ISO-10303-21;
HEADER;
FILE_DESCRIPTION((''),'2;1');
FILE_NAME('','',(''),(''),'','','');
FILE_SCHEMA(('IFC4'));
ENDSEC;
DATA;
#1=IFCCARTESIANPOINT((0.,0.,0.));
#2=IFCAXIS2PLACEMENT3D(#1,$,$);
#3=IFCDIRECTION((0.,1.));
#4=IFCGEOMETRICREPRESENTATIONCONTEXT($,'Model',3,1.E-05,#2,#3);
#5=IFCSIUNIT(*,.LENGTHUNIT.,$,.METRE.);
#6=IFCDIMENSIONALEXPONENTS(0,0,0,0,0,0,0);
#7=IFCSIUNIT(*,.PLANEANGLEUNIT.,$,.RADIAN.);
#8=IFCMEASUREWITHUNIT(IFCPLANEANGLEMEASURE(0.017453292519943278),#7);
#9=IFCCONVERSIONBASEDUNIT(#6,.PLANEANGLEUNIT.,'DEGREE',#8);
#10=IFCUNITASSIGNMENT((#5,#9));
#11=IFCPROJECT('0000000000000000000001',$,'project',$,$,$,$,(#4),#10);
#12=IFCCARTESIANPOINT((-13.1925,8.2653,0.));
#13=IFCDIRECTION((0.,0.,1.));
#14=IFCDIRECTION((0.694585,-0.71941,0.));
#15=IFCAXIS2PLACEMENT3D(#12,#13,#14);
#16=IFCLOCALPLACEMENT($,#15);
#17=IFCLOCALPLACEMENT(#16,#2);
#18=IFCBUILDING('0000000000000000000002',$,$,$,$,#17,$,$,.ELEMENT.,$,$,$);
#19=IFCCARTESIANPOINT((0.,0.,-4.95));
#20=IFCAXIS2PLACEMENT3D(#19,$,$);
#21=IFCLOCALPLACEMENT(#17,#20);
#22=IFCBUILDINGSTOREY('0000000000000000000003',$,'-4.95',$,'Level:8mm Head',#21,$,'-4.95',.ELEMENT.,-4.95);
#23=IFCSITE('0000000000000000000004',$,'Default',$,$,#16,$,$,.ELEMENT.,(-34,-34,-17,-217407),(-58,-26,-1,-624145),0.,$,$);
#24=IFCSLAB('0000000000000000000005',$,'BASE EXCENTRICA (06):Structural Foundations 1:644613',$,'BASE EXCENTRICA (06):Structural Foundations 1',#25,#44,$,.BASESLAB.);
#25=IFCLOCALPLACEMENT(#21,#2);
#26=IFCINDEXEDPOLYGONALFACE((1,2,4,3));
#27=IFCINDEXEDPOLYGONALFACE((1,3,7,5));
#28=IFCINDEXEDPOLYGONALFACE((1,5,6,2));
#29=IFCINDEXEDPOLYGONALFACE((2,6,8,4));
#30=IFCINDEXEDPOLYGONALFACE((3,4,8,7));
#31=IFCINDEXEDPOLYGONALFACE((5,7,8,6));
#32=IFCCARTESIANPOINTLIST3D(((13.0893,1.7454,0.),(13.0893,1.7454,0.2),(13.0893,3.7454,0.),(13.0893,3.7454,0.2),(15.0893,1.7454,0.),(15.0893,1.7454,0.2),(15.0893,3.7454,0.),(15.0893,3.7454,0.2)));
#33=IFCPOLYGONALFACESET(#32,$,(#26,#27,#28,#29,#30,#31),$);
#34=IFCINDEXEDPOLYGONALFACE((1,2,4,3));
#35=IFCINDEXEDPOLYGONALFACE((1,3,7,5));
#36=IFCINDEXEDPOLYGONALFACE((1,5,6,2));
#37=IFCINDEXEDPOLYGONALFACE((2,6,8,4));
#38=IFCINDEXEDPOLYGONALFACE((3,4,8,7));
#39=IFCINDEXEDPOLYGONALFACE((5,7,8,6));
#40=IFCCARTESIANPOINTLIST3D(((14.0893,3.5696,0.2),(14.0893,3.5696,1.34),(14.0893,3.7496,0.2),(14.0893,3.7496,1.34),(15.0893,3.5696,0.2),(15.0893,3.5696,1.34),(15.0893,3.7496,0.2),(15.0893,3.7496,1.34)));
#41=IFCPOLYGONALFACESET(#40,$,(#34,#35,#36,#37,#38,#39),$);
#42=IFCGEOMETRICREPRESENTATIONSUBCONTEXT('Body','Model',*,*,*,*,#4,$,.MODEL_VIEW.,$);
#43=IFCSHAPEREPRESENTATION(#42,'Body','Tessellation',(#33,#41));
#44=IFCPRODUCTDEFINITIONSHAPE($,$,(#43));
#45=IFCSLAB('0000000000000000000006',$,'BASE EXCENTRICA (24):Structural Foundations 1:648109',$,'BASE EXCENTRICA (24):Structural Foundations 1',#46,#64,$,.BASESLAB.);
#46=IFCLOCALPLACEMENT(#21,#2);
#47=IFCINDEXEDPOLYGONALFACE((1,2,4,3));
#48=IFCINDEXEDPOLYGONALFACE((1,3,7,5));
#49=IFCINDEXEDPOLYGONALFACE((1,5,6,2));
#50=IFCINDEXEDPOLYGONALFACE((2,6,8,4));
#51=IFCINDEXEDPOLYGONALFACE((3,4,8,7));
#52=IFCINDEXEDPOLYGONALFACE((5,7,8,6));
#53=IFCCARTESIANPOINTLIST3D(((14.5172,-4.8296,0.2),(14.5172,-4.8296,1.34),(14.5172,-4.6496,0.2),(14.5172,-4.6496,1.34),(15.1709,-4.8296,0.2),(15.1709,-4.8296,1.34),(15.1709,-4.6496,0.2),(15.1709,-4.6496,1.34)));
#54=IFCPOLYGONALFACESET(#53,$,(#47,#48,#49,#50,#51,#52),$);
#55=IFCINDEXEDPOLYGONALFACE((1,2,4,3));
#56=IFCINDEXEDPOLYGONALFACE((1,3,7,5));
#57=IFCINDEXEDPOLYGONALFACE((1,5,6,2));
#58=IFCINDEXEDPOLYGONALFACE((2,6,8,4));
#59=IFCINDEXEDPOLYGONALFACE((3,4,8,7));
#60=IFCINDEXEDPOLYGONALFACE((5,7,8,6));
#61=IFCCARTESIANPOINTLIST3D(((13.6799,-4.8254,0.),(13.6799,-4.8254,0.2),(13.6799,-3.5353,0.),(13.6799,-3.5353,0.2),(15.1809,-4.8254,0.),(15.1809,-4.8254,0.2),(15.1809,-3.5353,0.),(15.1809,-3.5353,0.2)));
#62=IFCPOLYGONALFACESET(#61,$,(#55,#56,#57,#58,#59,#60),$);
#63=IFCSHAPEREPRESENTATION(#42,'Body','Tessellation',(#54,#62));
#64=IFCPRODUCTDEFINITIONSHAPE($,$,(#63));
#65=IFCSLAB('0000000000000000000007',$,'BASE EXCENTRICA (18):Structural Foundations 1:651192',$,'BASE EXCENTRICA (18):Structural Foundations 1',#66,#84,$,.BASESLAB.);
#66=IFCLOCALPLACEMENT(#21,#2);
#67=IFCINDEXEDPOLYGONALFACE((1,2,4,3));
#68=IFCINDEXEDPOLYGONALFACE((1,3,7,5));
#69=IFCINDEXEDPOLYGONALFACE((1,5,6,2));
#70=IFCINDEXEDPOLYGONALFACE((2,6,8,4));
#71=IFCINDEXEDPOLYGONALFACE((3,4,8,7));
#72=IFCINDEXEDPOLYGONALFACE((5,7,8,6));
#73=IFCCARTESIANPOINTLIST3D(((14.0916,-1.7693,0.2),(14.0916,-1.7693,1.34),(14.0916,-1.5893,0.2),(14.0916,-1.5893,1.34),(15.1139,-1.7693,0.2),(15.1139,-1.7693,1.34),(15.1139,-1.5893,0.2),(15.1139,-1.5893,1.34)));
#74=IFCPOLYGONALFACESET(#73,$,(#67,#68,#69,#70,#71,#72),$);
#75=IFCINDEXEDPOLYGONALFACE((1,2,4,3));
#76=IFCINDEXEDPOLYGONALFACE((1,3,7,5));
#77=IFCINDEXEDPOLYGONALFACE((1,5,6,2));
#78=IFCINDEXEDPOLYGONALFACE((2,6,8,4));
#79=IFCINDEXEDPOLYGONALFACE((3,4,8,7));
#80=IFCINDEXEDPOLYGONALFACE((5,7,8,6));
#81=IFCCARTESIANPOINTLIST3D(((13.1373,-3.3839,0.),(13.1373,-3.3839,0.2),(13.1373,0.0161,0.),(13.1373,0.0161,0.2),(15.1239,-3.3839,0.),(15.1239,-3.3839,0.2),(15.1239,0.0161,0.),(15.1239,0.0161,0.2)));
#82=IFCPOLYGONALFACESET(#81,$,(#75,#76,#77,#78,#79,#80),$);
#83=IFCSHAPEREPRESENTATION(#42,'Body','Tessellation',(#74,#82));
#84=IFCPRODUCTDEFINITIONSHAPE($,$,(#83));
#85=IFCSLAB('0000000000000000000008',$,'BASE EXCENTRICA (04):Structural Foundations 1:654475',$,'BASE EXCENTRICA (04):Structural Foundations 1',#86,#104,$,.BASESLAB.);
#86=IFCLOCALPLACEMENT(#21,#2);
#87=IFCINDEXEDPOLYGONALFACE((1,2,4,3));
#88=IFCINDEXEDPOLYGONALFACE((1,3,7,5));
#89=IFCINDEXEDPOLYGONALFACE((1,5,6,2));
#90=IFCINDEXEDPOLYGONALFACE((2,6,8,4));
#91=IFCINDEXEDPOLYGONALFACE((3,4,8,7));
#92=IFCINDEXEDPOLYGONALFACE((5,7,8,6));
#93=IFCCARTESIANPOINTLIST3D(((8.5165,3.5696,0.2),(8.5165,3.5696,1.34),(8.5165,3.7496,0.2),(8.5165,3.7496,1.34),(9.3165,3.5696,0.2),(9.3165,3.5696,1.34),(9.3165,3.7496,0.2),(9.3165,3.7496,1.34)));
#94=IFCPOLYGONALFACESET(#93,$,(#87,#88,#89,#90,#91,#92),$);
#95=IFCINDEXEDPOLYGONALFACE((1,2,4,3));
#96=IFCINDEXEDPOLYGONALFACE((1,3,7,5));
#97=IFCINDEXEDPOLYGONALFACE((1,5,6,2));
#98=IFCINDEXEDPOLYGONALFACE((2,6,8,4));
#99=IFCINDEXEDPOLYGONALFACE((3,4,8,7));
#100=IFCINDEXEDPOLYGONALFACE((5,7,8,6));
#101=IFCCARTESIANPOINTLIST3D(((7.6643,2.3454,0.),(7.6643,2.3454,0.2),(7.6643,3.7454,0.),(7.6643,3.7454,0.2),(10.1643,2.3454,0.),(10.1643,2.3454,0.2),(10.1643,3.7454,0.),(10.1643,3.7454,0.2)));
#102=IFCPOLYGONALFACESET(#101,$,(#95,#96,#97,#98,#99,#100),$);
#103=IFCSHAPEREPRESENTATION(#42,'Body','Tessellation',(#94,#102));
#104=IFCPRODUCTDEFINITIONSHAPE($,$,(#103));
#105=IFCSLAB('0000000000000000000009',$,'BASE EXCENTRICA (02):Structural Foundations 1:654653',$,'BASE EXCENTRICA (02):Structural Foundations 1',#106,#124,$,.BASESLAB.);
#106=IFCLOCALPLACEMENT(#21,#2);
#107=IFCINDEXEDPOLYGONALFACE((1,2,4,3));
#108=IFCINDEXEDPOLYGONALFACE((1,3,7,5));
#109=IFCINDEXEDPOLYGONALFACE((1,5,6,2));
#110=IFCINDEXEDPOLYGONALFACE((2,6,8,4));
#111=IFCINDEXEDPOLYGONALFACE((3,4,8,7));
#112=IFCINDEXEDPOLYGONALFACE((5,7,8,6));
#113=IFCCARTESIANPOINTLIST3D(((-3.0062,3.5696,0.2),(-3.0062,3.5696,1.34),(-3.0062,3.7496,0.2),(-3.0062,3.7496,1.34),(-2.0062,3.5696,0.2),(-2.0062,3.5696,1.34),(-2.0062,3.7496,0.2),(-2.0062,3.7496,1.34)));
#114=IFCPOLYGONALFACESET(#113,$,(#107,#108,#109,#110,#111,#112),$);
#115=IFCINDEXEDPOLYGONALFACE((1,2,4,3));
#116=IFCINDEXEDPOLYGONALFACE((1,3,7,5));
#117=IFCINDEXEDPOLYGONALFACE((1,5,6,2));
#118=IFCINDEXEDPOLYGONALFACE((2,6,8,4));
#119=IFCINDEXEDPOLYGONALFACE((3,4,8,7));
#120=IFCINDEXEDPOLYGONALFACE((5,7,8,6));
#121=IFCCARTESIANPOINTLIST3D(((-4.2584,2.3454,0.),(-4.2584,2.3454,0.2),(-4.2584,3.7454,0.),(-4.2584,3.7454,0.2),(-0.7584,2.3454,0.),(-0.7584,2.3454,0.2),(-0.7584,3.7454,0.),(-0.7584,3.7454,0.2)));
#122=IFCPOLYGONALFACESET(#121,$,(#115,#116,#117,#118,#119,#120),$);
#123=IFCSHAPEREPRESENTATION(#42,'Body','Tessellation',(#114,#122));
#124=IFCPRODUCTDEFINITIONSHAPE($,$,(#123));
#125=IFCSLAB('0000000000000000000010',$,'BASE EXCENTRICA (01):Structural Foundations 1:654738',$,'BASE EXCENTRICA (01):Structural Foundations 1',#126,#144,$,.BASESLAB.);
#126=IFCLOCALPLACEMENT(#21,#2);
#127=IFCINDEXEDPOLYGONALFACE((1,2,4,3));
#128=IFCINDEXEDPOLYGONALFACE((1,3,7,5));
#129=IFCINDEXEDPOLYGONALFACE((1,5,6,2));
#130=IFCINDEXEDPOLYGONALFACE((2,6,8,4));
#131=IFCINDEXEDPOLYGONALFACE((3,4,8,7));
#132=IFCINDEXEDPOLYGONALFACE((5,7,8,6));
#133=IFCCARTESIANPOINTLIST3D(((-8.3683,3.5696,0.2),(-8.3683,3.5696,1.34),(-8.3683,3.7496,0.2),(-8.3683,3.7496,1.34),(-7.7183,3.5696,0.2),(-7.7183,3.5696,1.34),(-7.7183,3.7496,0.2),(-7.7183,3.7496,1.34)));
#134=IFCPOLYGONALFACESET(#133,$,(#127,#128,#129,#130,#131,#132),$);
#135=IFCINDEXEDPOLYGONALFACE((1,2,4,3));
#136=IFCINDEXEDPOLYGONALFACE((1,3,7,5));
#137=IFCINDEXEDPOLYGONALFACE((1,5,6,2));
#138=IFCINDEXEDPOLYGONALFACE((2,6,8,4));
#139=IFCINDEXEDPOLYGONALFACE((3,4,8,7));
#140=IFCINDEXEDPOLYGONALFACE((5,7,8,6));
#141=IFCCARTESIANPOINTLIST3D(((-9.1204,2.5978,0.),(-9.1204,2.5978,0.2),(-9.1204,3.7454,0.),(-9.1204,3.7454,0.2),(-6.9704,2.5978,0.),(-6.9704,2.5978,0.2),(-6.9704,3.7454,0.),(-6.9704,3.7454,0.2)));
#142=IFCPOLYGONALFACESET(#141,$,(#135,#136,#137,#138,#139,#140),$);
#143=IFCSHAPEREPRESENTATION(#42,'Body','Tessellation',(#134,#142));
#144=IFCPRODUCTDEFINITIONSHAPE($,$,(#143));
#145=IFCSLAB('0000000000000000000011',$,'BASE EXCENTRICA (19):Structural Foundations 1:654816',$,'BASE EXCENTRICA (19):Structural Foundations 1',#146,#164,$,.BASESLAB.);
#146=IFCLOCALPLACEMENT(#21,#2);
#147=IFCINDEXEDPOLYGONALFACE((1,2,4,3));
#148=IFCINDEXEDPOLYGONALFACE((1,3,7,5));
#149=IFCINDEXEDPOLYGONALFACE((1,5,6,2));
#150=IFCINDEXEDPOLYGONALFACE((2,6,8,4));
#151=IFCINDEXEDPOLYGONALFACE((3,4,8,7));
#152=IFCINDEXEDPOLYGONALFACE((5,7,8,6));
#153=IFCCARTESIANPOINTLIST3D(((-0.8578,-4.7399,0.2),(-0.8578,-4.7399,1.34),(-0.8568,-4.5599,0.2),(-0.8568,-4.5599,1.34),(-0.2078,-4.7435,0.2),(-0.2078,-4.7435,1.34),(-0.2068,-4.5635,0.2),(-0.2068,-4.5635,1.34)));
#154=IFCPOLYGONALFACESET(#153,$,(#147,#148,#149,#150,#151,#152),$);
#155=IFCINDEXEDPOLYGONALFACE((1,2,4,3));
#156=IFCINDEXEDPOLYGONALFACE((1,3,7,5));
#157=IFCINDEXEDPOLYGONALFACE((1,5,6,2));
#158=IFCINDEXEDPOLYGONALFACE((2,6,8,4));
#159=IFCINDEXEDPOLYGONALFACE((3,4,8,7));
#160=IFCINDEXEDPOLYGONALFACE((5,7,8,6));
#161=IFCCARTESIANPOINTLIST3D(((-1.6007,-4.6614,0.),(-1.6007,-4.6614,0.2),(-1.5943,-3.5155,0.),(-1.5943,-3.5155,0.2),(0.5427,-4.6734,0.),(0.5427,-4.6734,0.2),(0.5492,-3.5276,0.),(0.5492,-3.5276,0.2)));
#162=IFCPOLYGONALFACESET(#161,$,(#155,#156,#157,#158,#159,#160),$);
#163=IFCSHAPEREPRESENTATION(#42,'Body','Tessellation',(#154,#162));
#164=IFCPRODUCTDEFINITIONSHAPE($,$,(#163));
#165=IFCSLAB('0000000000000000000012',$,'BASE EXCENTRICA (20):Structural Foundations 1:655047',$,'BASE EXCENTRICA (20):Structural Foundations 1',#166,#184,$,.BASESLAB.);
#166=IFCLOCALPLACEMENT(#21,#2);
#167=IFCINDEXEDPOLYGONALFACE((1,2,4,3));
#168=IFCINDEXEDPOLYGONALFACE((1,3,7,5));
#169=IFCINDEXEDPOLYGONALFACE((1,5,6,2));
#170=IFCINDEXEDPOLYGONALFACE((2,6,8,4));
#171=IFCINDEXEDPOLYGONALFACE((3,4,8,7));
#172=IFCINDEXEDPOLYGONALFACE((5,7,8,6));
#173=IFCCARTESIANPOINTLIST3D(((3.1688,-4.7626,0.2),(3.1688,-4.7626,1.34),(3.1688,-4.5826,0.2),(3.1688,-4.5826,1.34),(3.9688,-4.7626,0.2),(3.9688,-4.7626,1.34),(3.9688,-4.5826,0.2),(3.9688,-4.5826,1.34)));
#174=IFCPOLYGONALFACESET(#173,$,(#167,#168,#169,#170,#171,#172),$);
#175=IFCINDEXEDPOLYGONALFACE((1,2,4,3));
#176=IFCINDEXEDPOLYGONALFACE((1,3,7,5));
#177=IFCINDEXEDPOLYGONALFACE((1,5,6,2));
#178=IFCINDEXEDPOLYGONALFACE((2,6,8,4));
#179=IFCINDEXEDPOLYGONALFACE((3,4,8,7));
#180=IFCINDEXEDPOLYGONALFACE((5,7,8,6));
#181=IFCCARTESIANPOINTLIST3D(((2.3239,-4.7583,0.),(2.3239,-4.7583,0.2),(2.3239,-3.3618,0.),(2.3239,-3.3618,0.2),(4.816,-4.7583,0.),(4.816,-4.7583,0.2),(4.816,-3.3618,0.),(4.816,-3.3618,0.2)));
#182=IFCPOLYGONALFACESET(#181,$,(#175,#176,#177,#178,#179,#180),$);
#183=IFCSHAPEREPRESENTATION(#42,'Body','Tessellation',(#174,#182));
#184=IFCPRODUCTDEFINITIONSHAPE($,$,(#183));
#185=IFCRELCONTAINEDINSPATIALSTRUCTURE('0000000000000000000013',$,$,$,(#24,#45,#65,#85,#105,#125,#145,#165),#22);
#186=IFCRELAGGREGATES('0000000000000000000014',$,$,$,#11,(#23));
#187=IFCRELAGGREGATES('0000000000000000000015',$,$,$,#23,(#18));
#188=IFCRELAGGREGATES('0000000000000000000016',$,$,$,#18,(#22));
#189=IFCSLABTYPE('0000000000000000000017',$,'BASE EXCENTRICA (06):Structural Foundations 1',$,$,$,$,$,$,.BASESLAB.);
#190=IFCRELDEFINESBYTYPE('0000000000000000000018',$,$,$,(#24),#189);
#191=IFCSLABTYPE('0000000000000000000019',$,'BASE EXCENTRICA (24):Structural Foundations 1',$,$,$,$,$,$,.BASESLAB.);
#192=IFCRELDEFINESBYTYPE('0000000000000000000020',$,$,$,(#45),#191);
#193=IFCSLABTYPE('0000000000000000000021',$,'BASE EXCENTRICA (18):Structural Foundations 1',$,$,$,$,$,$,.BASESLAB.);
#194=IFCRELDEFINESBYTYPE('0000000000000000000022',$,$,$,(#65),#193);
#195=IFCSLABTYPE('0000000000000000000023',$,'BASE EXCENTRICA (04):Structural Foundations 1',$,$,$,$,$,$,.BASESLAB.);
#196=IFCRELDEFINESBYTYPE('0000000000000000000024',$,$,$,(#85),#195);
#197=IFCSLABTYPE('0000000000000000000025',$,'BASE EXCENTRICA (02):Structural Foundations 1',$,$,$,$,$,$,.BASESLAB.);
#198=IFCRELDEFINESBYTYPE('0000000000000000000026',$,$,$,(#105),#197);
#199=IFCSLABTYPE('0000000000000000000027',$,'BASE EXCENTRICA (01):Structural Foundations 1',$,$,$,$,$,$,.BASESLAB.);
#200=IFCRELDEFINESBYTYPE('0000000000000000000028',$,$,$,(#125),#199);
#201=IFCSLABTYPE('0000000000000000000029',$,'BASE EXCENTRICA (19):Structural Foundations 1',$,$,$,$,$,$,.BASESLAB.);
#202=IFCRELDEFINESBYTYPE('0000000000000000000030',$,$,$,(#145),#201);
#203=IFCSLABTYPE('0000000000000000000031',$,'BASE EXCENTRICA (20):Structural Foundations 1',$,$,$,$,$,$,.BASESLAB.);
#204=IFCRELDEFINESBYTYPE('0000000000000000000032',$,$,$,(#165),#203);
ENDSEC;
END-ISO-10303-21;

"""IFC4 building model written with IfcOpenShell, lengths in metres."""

from ifc_helpers import new_model, entity, si_unit, converted_unit, direction, frame, origin, place, context, subcontext, project, spatial, indexed_curve, outline, extrude, type_object, element, save


model = new_model("IFC4")

# Units and contexts
model_context = context("Model", 3, precision=1e-05, world=origin(), true_north=direction((0.0, 1.0)))
body_context = subcontext(model_context, "Body", "Model", "MODEL_VIEW")
ifc_project = project(units=[si_unit("LENGTHUNIT", "METRE"), converted_unit("PLANEANGLEUNIT", "DEGREE", entity("IfcPlaneAngleMeasure", 0.017453292519943278), si_unit("PLANEANGLEUNIT", "RADIAN"), dimensions=[0, 0, 0, 0, 0, 0, 0])], contexts=[model_context])

# Site, building, storey
site_placement = place(None, frame((-13.1925, 8.2653, 0.0), z_axis=(0.0, 0.0, 1.0), x_axis=(0.694585, -0.71941, 0.0)))
site = spatial("IfcSite", under=ifc_project, at=site_placement, Name="Default", CompositionType="ELEMENT", RefLatitude=(-34, -34, -17, -217407), RefLongitude=(-58, -26, -1, -624145), RefElevation=0.0)
building_placement = place(site_placement, origin())
building = spatial("IfcBuilding", under=site, at=building_placement, CompositionType="ELEMENT")
storey_placement = place(building_placement, frame((0.0, 0.0, -4.95)))
storey = spatial("IfcBuildingStorey", under=building, at=storey_placement, Name="-4.95", ObjectType="Level:8mm Head", LongName="-4.95", CompositionType="ELEMENT", Elevation=-4.95)

# Slabs
slab_type_1 = type_object("IfcSlabType", Name="BASE EXCENTRICA (06):Structural Foundations 1", PredefinedType="BASESLAB")
slab_1_placement = place(storey_placement, origin())
element("IfcSlab", 1, at=slab_1_placement, inside=storey, type_object=slab_type_1, Name="BASE EXCENTRICA (06):Structural Foundations 1:644613", ObjectType="BASE EXCENTRICA (06):Structural Foundations 1", PredefinedType="BASESLAB", context=body_context, shape_type="SweptSolid", body=[
    extrude(outline(indexed_curve([(-1.0, -1.0), (1.0, -1.0), (1.0, 1.0), (-1.0, 1.0), (-1.0, -1.0)], self_intersect=False)), frame((14.0893, 2.7454, 0.0), z_axis=(0.0, 0.0, 1.0), x_axis=(0.0, -1.0, 0.0)), (0.0, 0.0, 1.0), 0.2),
    extrude(outline(indexed_curve([(-0.5, -0.09), (0.5, -0.09), (0.5, 0.09), (-0.5, 0.09), (-0.5, -0.09)], self_intersect=False)), frame((14.5893, 3.6596, 0.2), z_axis=(0.0, 0.0, 1.0), x_axis=(-1.0, 0.0, 0.0)), (0.0, 0.0, 1.0), 1.14),
])
slab_type_2 = type_object("IfcSlabType", Name="BASE EXCENTRICA (24):Structural Foundations 1", PredefinedType="BASESLAB")
slab_2_placement = place(storey_placement, origin())
element("IfcSlab", 2, at=slab_2_placement, inside=storey, type_object=slab_type_2, Name="BASE EXCENTRICA (24):Structural Foundations 1:648109", ObjectType="BASE EXCENTRICA (24):Structural Foundations 1", PredefinedType="BASESLAB", context=body_context, shape_type="SweptSolid", body=[
    extrude(outline(indexed_curve([(-0.09, -0.3268), (0.09, -0.3268), (0.09, 0.3268), (-0.09, 0.3268), (-0.09, -0.3268)], self_intersect=False)), frame((14.8441, -4.7396, 0.2), z_axis=(0.0, 0.0, 1.0), x_axis=(0.0, 1.0, 0.0)), (0.0, 0.0, 1.0), 1.14),
    extrude(outline(indexed_curve([(-0.7505, -0.645), (0.7505, -0.645), (0.7505, 0.645), (-0.7505, 0.645), (-0.7505, -0.645)], self_intersect=False)), frame((14.4304, -4.1803, 0.0)), (0.0, 0.0, 1.0), 0.2),
])
slab_type_3 = type_object("IfcSlabType", Name="BASE EXCENTRICA (18):Structural Foundations 1", PredefinedType="BASESLAB")
slab_3_placement = place(storey_placement, origin())
element("IfcSlab", 3, at=slab_3_placement, inside=storey, type_object=slab_type_3, Name="BASE EXCENTRICA (18):Structural Foundations 1:651192", ObjectType="BASE EXCENTRICA (18):Structural Foundations 1", PredefinedType="BASESLAB", context=body_context, shape_type="SweptSolid", body=[
    extrude(outline(indexed_curve([(-0.09, -0.5111), (0.09, -0.5111), (0.09, 0.5111), (-0.09, 0.5111), (-0.09, -0.5111)], self_intersect=False)), frame((14.6027, -1.6793, 0.2), z_axis=(0.0, 0.0, 1.0), x_axis=(0.0, 1.0, 0.0)), (0.0, 0.0, 1.0), 1.14),
    extrude(outline(indexed_curve([(-0.9933, -1.7), (0.9933, -1.7), (0.9933, 1.7), (-0.9933, 1.7), (-0.9933, -1.7)], self_intersect=False)), frame((14.1306, -1.6839, 0.0)), (0.0, 0.0, 1.0), 0.2),
])
slab_type_4 = type_object("IfcSlabType", Name="BASE EXCENTRICA (04):Structural Foundations 1", PredefinedType="BASESLAB")
slab_4_placement = place(storey_placement, origin())
element("IfcSlab", 4, at=slab_4_placement, inside=storey, type_object=slab_type_4, Name="BASE EXCENTRICA (04):Structural Foundations 1:654475", ObjectType="BASE EXCENTRICA (04):Structural Foundations 1", PredefinedType="BASESLAB", context=body_context, shape_type="SweptSolid", body=[
    extrude(outline(indexed_curve([(-0.4, -0.09), (0.4, -0.09), (0.4, 0.09), (-0.4, 0.09), (-0.4, -0.09)], self_intersect=False)), frame((8.9165, 3.6596, 0.2), z_axis=(0.0, 0.0, 1.0), x_axis=(-1.0, 0.0, 0.0)), (0.0, 0.0, 1.0), 1.14),
    extrude(outline(indexed_curve([(-0.7, -1.25), (0.7, -1.25), (0.7, 1.25), (-0.7, 1.25), (-0.7, -1.25)], self_intersect=False)), frame((8.9143, 3.0454, 0.0), z_axis=(0.0, 0.0, 1.0), x_axis=(0.0, -1.0, 0.0)), (0.0, 0.0, 1.0), 0.2),
])
slab_type_5 = type_object("IfcSlabType", Name="BASE EXCENTRICA (02):Structural Foundations 1", PredefinedType="BASESLAB")
slab_5_placement = place(storey_placement, origin())
element("IfcSlab", 5, at=slab_5_placement, inside=storey, type_object=slab_type_5, Name="BASE EXCENTRICA (02):Structural Foundations 1:654653", ObjectType="BASE EXCENTRICA (02):Structural Foundations 1", PredefinedType="BASESLAB", context=body_context, shape_type="SweptSolid", body=[
    extrude(outline(indexed_curve([(-0.5, -0.09), (0.5, -0.09), (0.5, 0.09), (-0.5, 0.09), (-0.5, -0.09)], self_intersect=False)), frame((-2.5062, 3.6596, 0.2), z_axis=(0.0, 0.0, 1.0), x_axis=(-1.0, 0.0, 0.0)), (0.0, 0.0, 1.0), 1.14),
    extrude(outline(indexed_curve([(-0.7, -1.75), (0.7, -1.75), (0.7, 1.75), (-0.7, 1.75), (-0.7, -1.75)], self_intersect=False)), frame((-2.5084, 3.0454, 0.0), z_axis=(0.0, 0.0, 1.0), x_axis=(0.0, -1.0, 0.0)), (0.0, 0.0, 1.0), 0.2),
])
slab_type_6 = type_object("IfcSlabType", Name="BASE EXCENTRICA (01):Structural Foundations 1", PredefinedType="BASESLAB")
slab_6_placement = place(storey_placement, origin())
element("IfcSlab", 6, at=slab_6_placement, inside=storey, type_object=slab_type_6, Name="BASE EXCENTRICA (01):Structural Foundations 1:654738", ObjectType="BASE EXCENTRICA (01):Structural Foundations 1", PredefinedType="BASESLAB", context=body_context, shape_type="SweptSolid", body=[
    extrude(outline(indexed_curve([(-0.325, -0.09), (0.325, -0.09), (0.325, 0.09), (-0.325, 0.09), (-0.325, -0.09)], self_intersect=False)), frame((-8.0433, 3.6596, 0.2), z_axis=(0.0, 0.0, 1.0), x_axis=(-1.0, 0.0, 0.0)), (0.0, 0.0, 1.0), 1.14),
    extrude(outline(indexed_curve([(-0.5738, -1.075), (0.5738, -1.075), (0.5738, 1.075), (-0.5738, 1.075), (-0.5738, -1.075)], self_intersect=False)), frame((-8.0454, 3.1716, 0.0), z_axis=(0.0, 0.0, 1.0), x_axis=(0.0, -1.0, 0.0)), (0.0, 0.0, 1.0), 0.2),
])
slab_type_7 = type_object("IfcSlabType", Name="BASE EXCENTRICA (19):Structural Foundations 1", PredefinedType="BASESLAB")
slab_7_placement = place(storey_placement, origin())
element("IfcSlab", 7, at=slab_7_placement, inside=storey, type_object=slab_type_7, Name="BASE EXCENTRICA (19):Structural Foundations 1:654816", ObjectType="BASE EXCENTRICA (19):Structural Foundations 1", PredefinedType="BASESLAB", context=body_context, shape_type="SweptSolid", body=[
    extrude(outline(indexed_curve([(-0.09, -0.325), (0.09, -0.325), (0.09, 0.325), (-0.09, 0.325), (-0.09, -0.325)], self_intersect=False)), frame((-0.5323, -4.6517, 0.2), z_axis=(0.0, 0.0, 1.0), x_axis=(0.005624, 0.999984, 0.0)), (0.0, 0.0, 1.0), 1.14),
    extrude(outline(indexed_curve([(-1.0718, -0.5729), (1.0718, -0.5729), (1.0718, 0.5729), (-1.0718, 0.5729), (-1.0718, -0.5729)], self_intersect=False)), frame((-0.5258, -4.0945, 0.0), z_axis=(0.0, 0.0, 1.0), x_axis=(0.999984, -0.005624, 0.0)), (0.0, 0.0, 1.0), 0.2),
])
slab_type_8 = type_object("IfcSlabType", Name="BASE EXCENTRICA (20):Structural Foundations 1", PredefinedType="BASESLAB")
slab_8_placement = place(storey_placement, origin())
element("IfcSlab", 8, at=slab_8_placement, inside=storey, type_object=slab_type_8, Name="BASE EXCENTRICA (20):Structural Foundations 1:655047", ObjectType="BASE EXCENTRICA (20):Structural Foundations 1", PredefinedType="BASESLAB", context=body_context, shape_type="SweptSolid", body=[
    extrude(outline(indexed_curve([(-0.09, -0.4), (0.09, -0.4), (0.09, 0.4), (-0.09, 0.4), (-0.09, -0.4)], self_intersect=False)), frame((3.5688, -4.6726, 0.2), z_axis=(0.0, 0.0, 1.0), x_axis=(0.0, 1.0, 0.0)), (0.0, 0.0, 1.0), 1.14),
    extrude(outline(indexed_curve([(-1.246, -0.6983), (1.246, -0.6983), (1.246, 0.6983), (-1.246, 0.6983), (-1.246, -0.6983)], self_intersect=False)), frame((3.57, -4.0601, 0.0)), (0.0, 0.0, 1.0), 0.2),
])

save(model, "model.ifc")
